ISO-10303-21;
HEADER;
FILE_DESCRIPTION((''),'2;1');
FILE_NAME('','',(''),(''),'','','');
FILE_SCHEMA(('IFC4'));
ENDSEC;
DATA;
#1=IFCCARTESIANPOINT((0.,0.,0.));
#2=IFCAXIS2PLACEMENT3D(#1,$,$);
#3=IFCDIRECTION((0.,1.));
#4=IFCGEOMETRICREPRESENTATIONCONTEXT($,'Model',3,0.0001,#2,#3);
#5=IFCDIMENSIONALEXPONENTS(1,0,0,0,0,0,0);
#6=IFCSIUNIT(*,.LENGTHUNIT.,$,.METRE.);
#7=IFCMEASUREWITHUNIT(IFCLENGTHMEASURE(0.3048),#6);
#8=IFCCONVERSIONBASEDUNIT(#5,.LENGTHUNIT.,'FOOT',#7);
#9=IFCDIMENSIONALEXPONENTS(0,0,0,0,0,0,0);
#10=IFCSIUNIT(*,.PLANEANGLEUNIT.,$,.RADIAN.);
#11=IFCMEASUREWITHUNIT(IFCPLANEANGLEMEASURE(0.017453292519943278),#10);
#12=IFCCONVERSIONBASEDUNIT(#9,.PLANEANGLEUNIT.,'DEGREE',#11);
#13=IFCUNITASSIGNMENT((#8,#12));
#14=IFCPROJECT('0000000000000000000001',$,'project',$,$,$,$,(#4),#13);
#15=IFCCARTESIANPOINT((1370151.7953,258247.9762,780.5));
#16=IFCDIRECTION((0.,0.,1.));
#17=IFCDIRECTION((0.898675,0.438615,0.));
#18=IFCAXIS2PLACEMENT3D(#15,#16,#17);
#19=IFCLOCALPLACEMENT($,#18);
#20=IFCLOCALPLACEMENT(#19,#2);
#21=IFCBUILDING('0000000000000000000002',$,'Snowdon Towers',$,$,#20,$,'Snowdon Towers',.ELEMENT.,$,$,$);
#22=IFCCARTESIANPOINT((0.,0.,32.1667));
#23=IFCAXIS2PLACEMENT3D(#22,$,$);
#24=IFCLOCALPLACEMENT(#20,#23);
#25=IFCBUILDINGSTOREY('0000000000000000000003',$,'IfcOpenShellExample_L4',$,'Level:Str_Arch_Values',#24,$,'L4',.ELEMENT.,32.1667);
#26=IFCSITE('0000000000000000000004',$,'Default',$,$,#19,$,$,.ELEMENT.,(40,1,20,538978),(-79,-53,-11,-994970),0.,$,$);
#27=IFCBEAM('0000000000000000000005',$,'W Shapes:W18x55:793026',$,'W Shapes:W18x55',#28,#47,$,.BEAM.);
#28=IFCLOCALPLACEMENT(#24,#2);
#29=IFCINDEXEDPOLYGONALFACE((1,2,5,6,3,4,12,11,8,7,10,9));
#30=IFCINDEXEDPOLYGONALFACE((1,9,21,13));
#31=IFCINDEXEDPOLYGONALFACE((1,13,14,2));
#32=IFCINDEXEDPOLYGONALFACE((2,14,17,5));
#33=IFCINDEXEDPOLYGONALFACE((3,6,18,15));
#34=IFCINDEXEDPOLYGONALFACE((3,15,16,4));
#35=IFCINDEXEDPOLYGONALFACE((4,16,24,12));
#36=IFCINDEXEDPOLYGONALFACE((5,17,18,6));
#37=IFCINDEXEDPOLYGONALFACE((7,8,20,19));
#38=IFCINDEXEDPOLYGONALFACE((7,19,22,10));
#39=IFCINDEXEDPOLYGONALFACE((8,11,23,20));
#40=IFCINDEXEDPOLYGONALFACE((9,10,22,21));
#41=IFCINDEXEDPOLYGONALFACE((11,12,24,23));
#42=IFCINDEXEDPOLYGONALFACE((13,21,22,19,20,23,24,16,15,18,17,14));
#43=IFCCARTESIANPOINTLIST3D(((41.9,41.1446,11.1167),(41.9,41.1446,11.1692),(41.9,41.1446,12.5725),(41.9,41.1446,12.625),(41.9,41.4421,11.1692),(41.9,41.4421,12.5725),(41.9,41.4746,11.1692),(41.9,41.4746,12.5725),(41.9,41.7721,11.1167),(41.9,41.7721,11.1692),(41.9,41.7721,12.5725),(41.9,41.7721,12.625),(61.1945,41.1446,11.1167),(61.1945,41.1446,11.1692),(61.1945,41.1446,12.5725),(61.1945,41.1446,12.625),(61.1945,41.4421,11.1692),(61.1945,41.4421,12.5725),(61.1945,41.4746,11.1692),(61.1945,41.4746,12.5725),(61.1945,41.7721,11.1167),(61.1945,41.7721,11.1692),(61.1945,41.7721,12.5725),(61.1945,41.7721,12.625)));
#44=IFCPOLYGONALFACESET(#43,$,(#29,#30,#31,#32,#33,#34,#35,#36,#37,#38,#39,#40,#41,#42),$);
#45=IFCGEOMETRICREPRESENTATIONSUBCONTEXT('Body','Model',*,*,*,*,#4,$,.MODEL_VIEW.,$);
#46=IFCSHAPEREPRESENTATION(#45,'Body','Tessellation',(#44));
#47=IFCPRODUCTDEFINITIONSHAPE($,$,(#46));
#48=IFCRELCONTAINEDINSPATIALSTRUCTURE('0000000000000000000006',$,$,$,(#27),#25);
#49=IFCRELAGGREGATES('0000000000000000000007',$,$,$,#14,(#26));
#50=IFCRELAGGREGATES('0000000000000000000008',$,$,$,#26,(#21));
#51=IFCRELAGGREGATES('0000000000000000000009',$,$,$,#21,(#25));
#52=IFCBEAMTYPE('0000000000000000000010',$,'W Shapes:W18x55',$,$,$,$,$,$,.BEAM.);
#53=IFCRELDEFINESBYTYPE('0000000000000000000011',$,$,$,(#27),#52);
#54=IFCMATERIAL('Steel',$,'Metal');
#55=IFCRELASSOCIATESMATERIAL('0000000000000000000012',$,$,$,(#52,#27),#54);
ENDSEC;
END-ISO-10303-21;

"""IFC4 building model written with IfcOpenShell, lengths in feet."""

from ifc_helpers import new_model, entity, si_unit, converted_unit, direction, frame, origin, place, context, subcontext, project, spatial, indexed_curve, outline, extrude, source, transform, mapped, material, type_object, type_shapes, element, save


model = new_model("IFC4")

# Units and contexts
model_context = context("Model", 3, precision=0.0001, world=origin(), true_north=direction((0.0, 1.0)))
body_context = subcontext(model_context, "Body", "Model", "MODEL_VIEW")
ifc_project = project(units=[converted_unit("LENGTHUNIT", "FOOT", entity("IfcLengthMeasure", 0.3048), si_unit("LENGTHUNIT", "METRE"), dimensions=[1, 0, 0, 0, 0, 0, 0]), converted_unit("PLANEANGLEUNIT", "DEGREE", entity("IfcPlaneAngleMeasure", 0.017453292519943278), si_unit("PLANEANGLEUNIT", "RADIAN"), dimensions=[0, 0, 0, 0, 0, 0, 0])], contexts=[model_context])

# Site, building, storey
site_placement = place(None, frame((1370151.7953, 258247.9762, 780.5), z_axis=(0.0, 0.0, 1.0), x_axis=(0.898675, 0.438615, 0.0)))
site = spatial("IfcSite", under=ifc_project, at=site_placement, Name="Default", CompositionType="ELEMENT", RefLatitude=(40, 1, 20, 538978), RefLongitude=(-79, -53, -11, -994970), RefElevation=0.0)
building_placement = place(site_placement, origin())
building = spatial("IfcBuilding", under=site, at=building_placement, Name="Snowdon Towers", LongName="Snowdon Towers", CompositionType="ELEMENT")
storey_placement = place(building_placement, frame((0.0, 0.0, 32.1667)))
storey = spatial("IfcBuildingStorey", under=building, at=storey_placement, Name="IfcOpenShellExample_L4", ObjectType="Level:Str_Arch_Values", LongName="L4", CompositionType="ELEMENT", Elevation=32.1667)

# Shared definitions
ifc_material = material(Name="Steel", Category="Metal")

# Beam
beam_type_1 = type_object("IfcBeamType", Name="W Shapes:W18x55", PredefinedType="BEAM", material=ifc_material)
shared_shape_1 = source(origin(), body_context, "Body", "SweptSolid", [
    extrude(outline(indexed_curve([(-0.3138, -0.7017), (-0.3138, -0.7542), (0.3138, -0.7542), (0.3138, -0.7017), (0.0162, -0.7017), (0.0162, 0.7017), (0.3138, 0.7017), (0.3138, 0.7542), (-0.3137, 0.7542), (-0.3137, 0.7017), (-0.0163, 0.7017), (-0.0163, -0.7017), (-0.3138, -0.7017)], self_intersect=False)), frame((-9.9242, 0.0, 0.0), z_axis=(-1.0, 0.0, 0.0), x_axis=(0.0, -1.0, 0.0)), (0.0, 0.0, -1.0), 19.2945),
])
type_shapes(beam_type_1, [shared_shape_1])
beam_1_placement = place(storey_placement, frame((51.8242, 41.4583, 11.8708)))
element("IfcBeam", 1, at=beam_1_placement, inside=storey, type_object=beam_type_1, material=ifc_material, Name="W Shapes:W18x55:793026", ObjectType="W Shapes:W18x55", PredefinedType="BEAM", context=body_context, shape_type="MappedRepresentation", body=[
    mapped(shared_shape_1, transform((0.0, 0.0, 0.0), scale=1.0)),
])

save(model, "model.ifc")
